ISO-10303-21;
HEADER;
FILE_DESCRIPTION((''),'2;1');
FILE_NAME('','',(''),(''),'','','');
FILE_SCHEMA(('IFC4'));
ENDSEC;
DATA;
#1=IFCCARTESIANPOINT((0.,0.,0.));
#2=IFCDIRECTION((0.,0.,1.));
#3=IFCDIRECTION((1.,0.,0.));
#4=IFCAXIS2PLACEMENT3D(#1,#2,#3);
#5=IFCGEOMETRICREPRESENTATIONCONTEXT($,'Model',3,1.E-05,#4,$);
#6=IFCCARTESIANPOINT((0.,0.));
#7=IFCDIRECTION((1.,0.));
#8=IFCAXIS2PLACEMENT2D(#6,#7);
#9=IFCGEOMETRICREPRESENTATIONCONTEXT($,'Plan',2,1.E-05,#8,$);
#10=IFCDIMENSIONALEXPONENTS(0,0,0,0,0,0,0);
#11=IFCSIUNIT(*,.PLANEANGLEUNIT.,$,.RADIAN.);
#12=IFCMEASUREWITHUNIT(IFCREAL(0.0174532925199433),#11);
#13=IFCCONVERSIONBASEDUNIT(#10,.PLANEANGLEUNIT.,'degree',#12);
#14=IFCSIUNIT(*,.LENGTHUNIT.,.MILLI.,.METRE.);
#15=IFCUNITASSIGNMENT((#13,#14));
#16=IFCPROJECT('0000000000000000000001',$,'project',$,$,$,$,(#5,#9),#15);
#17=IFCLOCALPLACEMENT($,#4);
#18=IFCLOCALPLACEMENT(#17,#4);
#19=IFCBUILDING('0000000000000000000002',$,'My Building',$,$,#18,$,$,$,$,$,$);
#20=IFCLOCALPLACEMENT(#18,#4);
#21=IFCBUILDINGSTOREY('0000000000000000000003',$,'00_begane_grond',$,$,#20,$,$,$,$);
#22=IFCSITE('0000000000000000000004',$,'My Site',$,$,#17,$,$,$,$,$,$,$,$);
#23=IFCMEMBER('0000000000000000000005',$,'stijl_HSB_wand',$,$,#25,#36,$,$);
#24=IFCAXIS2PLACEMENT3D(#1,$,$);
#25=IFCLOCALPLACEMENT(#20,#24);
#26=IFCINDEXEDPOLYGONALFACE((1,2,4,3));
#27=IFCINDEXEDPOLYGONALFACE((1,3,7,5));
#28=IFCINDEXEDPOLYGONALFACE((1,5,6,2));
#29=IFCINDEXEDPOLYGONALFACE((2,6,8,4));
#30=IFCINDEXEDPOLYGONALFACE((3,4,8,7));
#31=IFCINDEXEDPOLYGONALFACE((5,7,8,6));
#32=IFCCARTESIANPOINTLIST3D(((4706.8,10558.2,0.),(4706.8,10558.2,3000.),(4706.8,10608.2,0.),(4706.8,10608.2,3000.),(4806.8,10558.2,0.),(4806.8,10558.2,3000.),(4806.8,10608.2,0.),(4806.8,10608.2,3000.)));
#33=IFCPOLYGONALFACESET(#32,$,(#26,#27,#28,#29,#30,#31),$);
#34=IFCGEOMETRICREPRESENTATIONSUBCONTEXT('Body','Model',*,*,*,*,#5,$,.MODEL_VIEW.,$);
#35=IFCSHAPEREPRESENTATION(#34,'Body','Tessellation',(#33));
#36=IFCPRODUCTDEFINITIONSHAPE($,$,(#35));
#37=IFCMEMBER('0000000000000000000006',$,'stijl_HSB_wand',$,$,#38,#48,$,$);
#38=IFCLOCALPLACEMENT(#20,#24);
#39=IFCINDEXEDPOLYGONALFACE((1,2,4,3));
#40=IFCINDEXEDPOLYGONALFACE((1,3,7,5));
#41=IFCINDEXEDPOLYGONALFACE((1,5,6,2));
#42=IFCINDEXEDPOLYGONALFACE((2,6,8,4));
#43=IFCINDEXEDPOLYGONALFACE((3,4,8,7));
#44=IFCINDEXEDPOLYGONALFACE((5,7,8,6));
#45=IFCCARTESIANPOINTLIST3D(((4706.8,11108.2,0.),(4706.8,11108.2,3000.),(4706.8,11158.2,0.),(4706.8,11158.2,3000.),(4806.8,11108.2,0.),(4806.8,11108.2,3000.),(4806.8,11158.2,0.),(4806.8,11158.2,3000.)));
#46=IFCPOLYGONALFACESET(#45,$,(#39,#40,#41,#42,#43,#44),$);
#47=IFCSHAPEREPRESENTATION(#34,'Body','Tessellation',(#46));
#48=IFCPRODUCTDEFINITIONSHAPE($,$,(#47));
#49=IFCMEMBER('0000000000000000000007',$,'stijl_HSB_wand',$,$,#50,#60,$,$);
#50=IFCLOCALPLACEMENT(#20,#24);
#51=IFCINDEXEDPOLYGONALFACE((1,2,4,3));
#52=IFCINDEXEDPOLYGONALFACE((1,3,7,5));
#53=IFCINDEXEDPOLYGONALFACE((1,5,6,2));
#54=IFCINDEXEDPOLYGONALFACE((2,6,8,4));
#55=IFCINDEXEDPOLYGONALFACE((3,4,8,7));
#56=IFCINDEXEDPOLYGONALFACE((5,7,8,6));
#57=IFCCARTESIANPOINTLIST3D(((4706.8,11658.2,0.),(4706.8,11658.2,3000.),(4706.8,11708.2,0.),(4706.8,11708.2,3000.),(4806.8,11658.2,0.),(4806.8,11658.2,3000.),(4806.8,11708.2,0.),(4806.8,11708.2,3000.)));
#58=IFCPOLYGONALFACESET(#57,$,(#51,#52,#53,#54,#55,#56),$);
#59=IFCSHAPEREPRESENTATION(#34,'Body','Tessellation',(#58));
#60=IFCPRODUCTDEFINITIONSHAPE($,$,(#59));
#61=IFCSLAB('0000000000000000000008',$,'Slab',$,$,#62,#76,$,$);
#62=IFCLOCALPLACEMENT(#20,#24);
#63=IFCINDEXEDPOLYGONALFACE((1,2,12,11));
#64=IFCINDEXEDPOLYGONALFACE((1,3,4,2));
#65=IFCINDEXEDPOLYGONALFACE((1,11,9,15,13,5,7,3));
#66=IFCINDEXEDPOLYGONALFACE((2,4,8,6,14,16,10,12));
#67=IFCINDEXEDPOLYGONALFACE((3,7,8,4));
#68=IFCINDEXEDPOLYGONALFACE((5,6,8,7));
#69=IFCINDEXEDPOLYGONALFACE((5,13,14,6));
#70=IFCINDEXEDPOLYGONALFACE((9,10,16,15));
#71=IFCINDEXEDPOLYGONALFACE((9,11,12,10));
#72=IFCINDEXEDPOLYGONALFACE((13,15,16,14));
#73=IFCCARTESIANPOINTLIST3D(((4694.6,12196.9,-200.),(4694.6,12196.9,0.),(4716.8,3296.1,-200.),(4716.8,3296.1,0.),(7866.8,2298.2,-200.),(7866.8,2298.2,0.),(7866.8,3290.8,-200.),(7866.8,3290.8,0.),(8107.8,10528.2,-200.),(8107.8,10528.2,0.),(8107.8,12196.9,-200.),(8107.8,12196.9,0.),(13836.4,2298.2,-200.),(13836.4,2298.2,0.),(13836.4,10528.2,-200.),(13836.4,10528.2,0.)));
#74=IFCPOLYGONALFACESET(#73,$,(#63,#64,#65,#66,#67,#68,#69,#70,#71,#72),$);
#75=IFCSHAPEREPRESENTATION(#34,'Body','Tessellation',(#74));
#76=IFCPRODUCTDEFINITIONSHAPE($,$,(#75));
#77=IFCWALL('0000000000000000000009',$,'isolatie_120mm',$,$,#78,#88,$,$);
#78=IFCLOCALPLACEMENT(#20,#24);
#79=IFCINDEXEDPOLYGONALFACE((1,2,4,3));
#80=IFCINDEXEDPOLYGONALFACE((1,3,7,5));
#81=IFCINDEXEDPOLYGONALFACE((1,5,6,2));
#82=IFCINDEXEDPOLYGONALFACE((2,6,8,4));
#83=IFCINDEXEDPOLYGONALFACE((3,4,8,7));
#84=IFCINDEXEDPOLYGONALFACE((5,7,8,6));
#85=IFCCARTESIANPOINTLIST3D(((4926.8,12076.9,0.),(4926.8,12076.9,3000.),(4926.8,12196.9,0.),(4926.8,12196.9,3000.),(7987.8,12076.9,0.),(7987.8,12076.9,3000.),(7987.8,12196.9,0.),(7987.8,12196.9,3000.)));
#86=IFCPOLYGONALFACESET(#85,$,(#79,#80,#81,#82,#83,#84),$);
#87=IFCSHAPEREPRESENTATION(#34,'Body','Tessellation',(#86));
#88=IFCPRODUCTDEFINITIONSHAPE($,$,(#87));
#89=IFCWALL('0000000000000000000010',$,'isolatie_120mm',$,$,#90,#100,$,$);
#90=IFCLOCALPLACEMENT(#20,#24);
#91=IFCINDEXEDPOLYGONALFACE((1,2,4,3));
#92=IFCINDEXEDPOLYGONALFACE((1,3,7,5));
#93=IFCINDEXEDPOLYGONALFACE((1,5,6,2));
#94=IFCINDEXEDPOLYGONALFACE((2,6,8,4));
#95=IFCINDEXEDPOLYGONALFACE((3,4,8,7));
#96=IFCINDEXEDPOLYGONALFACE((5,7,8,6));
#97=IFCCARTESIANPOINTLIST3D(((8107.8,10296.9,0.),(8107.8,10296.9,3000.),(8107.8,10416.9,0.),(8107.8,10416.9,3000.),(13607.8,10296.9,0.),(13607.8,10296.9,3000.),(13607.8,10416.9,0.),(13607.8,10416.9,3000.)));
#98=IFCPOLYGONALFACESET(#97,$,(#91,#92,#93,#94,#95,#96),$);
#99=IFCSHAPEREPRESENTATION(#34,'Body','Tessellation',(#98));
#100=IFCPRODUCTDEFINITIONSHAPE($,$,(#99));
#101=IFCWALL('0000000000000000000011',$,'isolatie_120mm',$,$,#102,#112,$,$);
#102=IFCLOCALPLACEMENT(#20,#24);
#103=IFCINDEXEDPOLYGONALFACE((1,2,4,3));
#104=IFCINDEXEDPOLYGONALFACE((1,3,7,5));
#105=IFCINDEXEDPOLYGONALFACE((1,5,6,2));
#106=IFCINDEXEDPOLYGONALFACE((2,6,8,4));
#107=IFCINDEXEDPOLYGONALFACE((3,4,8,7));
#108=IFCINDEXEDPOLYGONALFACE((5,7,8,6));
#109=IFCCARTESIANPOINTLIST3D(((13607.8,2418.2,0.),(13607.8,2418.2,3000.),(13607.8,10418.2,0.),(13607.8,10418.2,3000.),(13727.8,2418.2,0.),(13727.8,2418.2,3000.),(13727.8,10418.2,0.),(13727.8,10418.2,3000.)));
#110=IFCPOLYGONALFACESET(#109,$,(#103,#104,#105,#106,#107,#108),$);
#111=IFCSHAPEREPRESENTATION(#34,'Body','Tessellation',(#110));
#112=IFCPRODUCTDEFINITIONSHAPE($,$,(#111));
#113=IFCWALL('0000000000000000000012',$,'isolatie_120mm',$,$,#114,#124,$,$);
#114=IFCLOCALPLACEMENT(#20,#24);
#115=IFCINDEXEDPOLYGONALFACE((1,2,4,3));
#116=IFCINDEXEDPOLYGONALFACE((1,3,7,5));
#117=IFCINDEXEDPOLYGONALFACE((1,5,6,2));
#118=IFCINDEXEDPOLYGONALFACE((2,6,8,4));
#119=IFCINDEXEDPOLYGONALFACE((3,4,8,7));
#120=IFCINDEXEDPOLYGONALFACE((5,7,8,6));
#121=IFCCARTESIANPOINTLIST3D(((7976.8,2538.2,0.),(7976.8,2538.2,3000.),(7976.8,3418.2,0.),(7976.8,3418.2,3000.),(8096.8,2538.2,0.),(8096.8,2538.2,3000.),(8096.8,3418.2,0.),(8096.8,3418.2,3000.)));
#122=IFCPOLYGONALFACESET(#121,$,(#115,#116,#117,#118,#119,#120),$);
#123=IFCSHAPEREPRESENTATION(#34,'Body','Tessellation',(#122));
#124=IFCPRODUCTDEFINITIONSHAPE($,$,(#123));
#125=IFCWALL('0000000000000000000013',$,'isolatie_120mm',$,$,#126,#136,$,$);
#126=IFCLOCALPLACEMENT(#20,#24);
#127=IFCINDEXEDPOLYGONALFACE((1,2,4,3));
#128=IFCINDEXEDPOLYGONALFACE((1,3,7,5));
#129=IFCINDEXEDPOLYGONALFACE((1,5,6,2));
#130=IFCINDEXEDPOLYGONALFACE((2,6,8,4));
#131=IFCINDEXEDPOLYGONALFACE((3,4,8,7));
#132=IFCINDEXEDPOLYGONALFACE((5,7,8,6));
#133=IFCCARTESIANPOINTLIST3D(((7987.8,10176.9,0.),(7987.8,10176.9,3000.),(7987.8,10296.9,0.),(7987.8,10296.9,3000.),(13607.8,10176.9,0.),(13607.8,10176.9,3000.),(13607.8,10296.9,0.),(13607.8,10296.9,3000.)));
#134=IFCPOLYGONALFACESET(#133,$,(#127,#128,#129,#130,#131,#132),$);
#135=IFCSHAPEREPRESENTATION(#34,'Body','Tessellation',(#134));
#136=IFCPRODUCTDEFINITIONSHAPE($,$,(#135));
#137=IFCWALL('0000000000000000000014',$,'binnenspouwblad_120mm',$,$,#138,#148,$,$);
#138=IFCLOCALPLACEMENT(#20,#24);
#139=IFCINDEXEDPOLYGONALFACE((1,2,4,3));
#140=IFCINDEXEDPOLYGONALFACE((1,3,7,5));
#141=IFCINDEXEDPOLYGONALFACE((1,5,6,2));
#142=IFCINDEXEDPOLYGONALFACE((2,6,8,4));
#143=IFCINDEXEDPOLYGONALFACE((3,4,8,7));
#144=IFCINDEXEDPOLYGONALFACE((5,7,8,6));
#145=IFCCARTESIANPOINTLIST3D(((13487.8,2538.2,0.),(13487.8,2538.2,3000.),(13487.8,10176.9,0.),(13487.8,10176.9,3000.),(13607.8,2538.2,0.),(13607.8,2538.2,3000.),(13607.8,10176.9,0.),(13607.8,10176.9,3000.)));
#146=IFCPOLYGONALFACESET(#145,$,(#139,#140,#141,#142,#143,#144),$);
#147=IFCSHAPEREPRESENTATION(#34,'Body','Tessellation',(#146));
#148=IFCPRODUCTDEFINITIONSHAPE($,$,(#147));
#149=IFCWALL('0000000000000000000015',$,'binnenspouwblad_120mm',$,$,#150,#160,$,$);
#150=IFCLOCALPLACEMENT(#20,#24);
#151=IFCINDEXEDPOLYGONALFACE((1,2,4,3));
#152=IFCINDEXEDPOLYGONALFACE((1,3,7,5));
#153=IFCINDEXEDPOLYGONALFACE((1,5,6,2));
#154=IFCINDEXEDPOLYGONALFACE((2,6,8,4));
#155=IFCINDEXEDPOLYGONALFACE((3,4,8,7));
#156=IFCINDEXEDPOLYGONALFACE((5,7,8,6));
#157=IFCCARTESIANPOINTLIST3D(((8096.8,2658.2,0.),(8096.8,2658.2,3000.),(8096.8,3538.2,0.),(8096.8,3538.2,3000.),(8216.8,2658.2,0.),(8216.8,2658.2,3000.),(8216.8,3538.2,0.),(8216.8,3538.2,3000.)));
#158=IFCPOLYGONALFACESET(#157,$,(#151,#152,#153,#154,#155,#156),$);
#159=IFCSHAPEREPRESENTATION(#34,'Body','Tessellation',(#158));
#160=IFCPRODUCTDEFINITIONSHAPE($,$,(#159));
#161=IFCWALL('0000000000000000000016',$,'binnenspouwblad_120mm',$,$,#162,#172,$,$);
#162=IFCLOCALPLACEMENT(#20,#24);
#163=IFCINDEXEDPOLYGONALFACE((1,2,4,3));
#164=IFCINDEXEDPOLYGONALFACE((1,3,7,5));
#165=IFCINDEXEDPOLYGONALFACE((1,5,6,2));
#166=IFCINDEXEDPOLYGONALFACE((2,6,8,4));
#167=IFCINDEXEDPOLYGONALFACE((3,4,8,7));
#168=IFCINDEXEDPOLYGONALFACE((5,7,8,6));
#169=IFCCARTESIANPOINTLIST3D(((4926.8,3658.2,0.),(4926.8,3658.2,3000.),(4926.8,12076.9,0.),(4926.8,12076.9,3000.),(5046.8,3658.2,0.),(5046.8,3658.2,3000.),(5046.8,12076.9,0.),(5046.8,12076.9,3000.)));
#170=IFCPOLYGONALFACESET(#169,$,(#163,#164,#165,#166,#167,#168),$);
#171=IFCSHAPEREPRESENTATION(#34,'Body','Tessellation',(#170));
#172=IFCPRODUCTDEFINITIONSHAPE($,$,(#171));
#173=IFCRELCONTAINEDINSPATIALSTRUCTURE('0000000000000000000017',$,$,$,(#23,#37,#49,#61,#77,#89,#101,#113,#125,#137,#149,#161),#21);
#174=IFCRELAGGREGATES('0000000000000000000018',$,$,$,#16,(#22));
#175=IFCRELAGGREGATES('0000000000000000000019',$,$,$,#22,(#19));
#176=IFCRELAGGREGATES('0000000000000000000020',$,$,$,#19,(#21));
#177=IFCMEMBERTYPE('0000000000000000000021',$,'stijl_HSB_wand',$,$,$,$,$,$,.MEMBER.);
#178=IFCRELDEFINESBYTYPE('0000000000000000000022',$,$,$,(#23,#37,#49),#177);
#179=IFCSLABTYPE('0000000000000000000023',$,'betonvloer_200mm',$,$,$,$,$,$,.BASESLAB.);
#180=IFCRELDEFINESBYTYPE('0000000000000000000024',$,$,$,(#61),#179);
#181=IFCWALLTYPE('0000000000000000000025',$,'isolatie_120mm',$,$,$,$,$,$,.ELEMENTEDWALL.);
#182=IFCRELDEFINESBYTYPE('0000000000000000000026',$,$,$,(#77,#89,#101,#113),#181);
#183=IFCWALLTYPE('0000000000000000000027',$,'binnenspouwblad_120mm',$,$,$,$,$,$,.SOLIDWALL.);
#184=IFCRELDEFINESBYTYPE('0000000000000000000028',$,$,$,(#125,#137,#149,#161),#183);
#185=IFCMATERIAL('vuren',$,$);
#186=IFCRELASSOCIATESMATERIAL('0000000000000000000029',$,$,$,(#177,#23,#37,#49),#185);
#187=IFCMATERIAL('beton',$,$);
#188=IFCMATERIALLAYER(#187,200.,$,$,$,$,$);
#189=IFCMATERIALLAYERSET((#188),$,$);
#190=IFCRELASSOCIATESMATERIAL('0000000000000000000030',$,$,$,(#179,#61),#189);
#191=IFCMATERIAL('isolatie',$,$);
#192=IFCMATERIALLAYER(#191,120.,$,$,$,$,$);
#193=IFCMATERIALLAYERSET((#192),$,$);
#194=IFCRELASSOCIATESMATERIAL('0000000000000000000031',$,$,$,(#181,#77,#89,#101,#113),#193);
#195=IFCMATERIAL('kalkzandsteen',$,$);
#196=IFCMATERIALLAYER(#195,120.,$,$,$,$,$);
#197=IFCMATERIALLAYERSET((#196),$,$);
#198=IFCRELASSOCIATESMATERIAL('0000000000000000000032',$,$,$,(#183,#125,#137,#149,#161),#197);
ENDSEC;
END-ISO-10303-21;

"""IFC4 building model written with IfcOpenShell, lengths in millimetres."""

from ifc_helpers import new_model, entity, si_unit, converted_unit, frame, origin_with_axes, origin_2d_with_axis, place, context, subcontext, project, spatial, line, indexed_curve, rectangle, outline, extrude, material, layer, layer_set, layer_usage, material_profile, profile_set, profile_usage, type_object, element, save


model = new_model("IFC4")

# Units and contexts
model_context = context("Model", 3, precision=1e-05, world=origin_with_axes())
plan_context = context("Plan", 2, precision=1e-05, world=origin_2d_with_axis())
body_context = subcontext(model_context, "Body", "Model", "MODEL_VIEW")
ifc_project = project(units=[converted_unit("PLANEANGLEUNIT", "degree", entity("IfcReal", 0.0174532925199433), si_unit("PLANEANGLEUNIT", "RADIAN"), dimensions=[0, 0, 0, 0, 0, 0, 0]), si_unit("LENGTHUNIT", "METRE", prefix="MILLI")], contexts=[model_context, plan_context])

# Site, building, storey
site_placement = place(None, origin_with_axes())
site = spatial("IfcSite", under=ifc_project, at=site_placement, Name="My Site")
building_placement = place(site_placement, origin_with_axes())
building = spatial("IfcBuilding", under=site, at=building_placement, Name="My Building")
storey_placement = place(building_placement, origin_with_axes())
storey = spatial("IfcBuildingStorey", under=building, at=storey_placement, Name="00_begane_grond")

# Members
ifc_material_1 = material(Name="vuren")
ifc_material_profile_1 = material_profile(ifc_material_1, rectangle(XDim=100.0, YDim=50.0))
ifc_material_profile_2 = material_profile(ifc_material_1, rectangle(XDim=100.0, YDim=50.0))
ifc_profile_set = profile_set([ifc_material_profile_1, ifc_material_profile_2])
member_type = type_object("IfcMemberType", Name="stijl_HSB_wand", PredefinedType="MEMBER", material=ifc_profile_set)
ifc_profile_usage_1 = profile_usage(ifc_profile_set, cardinal=1)
member_1_placement = place(storey_placement, frame((4806.8, 10558.2, 0.0), z_axis=(0.0, 0.0, 1.0), x_axis=(1.0, 0.0, 0.0)))
element("IfcMember", 1, at=member_1_placement, inside=storey, type_object=member_type, material=ifc_profile_usage_1, Name="stijl_HSB_wand", context=body_context, shape_type="SweptSolid", body=[
    extrude(rectangle(XDim=100.0, YDim=50.0), frame((-50.0, 25.0, 0.0), z_axis=(0.0, 0.0, 1.0), x_axis=(1.0, 0.0, 0.0)), (0.0, 0.0, 1.0), 3000.0),
])
ifc_profile_usage_2 = profile_usage(ifc_profile_set, cardinal=1)
member_2_placement = place(storey_placement, frame((4806.8, 11108.2, 0.0), z_axis=(0.0, 0.0, 1.0), x_axis=(1.0, 0.0, 0.0)))
element("IfcMember", 2, at=member_2_placement, inside=storey, type_object=member_type, material=ifc_profile_usage_2, Name="stijl_HSB_wand", context=body_context, shape_type="SweptSolid", body=[
    extrude(rectangle(XDim=100.0, YDim=50.0), frame((-50.0, 25.0, 0.0), z_axis=(0.0, 0.0, 1.0), x_axis=(1.0, 0.0, 0.0)), (0.0, 0.0, 1.0), 3000.0),
])
ifc_profile_usage_3 = profile_usage(ifc_profile_set, cardinal=1)
member_3_placement = place(storey_placement, frame((4806.8, 11658.2, 0.0), z_axis=(0.0, 0.0, 1.0), x_axis=(1.0, 0.0, 0.0)))
element("IfcMember", 3, at=member_3_placement, inside=storey, type_object=member_type, material=ifc_profile_usage_3, Name="stijl_HSB_wand", context=body_context, shape_type="SweptSolid", body=[
    extrude(rectangle(XDim=100.0, YDim=50.0), frame((-50.0, 25.0, 0.0), z_axis=(0.0, 0.0, 1.0), x_axis=(1.0, 0.0, 0.0)), (0.0, 0.0, 1.0), 3000.0),
])

# Slab
ifc_material_2 = material(Name="beton")
ifc_layer_1 = layer(ifc_material_2, 200.0)
ifc_layer_set_1 = layer_set([ifc_layer_1])
ifc_layer_usage_1 = layer_usage(ifc_layer_set_1, "AXIS3", "POSITIVE", 0.0)
slab_type = type_object("IfcSlabType", Name="betonvloer_200mm", PredefinedType="BASESLAB", material=ifc_layer_set_1)
slab_placement = place(storey_placement, frame((7866.8, 2298.2, -200.0), z_axis=(0.0, 0.0, 1.0), x_axis=(1.0, 0.0, 0.0)))
element("IfcSlab", 4, at=slab_placement, inside=storey, type_object=slab_type, material=ifc_layer_usage_1, Name="Slab", context=body_context, shape_type="SweptSolid", body=[
    extrude(outline(indexed_curve([(241.0, 9898.8), (0.0, 0.0), (5969.7, 0.0), (241.0, 8230.0), (0.0, 992.6), (-3150.0, 997.9), (-3172.1, 9898.8), (5969.7, 8230.0)], segments=[line(5, 2), line(2, 3), line(3, 8), line(8, 4), line(4, 1), line(1, 7), line(7, 6), line(6, 5)], self_intersect=False)), None, (0.0, 0.0, 1.0), 200.0),
])

# Walls
ifc_material_3 = material(Name="isolatie")
ifc_layer_2 = layer(ifc_material_3, 120.0)
ifc_layer_set_2 = layer_set([ifc_layer_2])
ifc_layer_usage_2 = layer_usage(ifc_layer_set_2, "AXIS2", "POSITIVE", 0.0)
wall_type_1 = type_object("IfcWallType", Name="isolatie_120mm", PredefinedType="ELEMENTEDWALL", material=ifc_layer_set_2)
wall_1_placement = place(storey_placement, frame((4926.8, 12076.9, 0.0), z_axis=(0.0, 0.0, 1.0), x_axis=(1.0, 0.0, 0.0)))
element("IfcWall", 5, at=wall_1_placement, inside=storey, type_object=wall_type_1, material=ifc_layer_usage_2, Name="isolatie_120mm", context=body_context, shape_type="SweptSolid", body=[
    extrude(outline(indexed_curve([(0.0, 0.0), (0.0, 120.0), (3061.0, 120.0), (3061.0, 0.0), (0.0, 0.0)], self_intersect=False)), origin_with_axes(), (0.0, 0.0, 1.0), 3000.0),
])
ifc_layer_usage_3 = layer_usage(ifc_layer_set_2, "AXIS2", "POSITIVE", 0.0)
wall_2_placement = place(storey_placement, frame((8107.8, 10296.9, 0.0), z_axis=(0.0, 0.0, 1.0), x_axis=(1.0, -0.000001, 0.0)))
element("IfcWall", 6, at=wall_2_placement, inside=storey, type_object=wall_type_1, material=ifc_layer_usage_3, Name="isolatie_120mm", context=body_context, shape_type="SweptSolid", body=[
    extrude(outline(indexed_curve([(0.0, 0.0), (0.0, 120.0), (5500.0, 120.0), (5500.0, 0.0), (0.0, 0.0)], self_intersect=False)), origin_with_axes(), (0.0, 0.0, 1.0), 3000.0),
])
ifc_layer_usage_4 = layer_usage(ifc_layer_set_2, "AXIS2", "POSITIVE", 0.0)
wall_3_placement = place(storey_placement, frame((13607.8, 10418.2, 0.0), z_axis=(0.0, 0.0, 1.0), x_axis=(-0.000001, -1.0, 0.0)))
element("IfcWall", 7, at=wall_3_placement, inside=storey, type_object=wall_type_1, material=ifc_layer_usage_4, Name="isolatie_120mm", context=body_context, shape_type="SweptSolid", body=[
    extrude(outline(indexed_curve([(0.0, 0.0), (0.0, 120.0), (8000.0, 120.0), (8000.0, 0.0), (0.0, 0.0)], self_intersect=False)), origin_with_axes(), (0.0, 0.0, 1.0), 3000.0),
])
ifc_layer_usage_5 = layer_usage(ifc_layer_set_2, "AXIS2", "POSITIVE", 0.0)
wall_4_placement = place(storey_placement, frame((7976.8, 3418.2, 0.0), z_axis=(0.0, 0.0, 1.0), x_axis=(0.0, -1.0, 0.0)))
element("IfcWall", 8, at=wall_4_placement, inside=storey, type_object=wall_type_1, material=ifc_layer_usage_5, Name="isolatie_120mm", context=body_context, shape_type="SweptSolid", body=[
    extrude(outline(indexed_curve([(0.0, 0.0), (0.0, 120.0), (880.0, 120.0), (880.0, 0.0), (0.0, 0.0)], self_intersect=False)), origin_with_axes(), (0.0, 0.0, 1.0), 3000.0),
])
ifc_material_4 = material(Name="kalkzandsteen")
ifc_layer_3 = layer(ifc_material_4, 120.0)
ifc_layer_set_3 = layer_set([ifc_layer_3])
ifc_layer_usage_6 = layer_usage(ifc_layer_set_3, "AXIS2", "POSITIVE", 0.0)
wall_type_2 = type_object("IfcWallType", Name="binnenspouwblad_120mm", PredefinedType="SOLIDWALL", material=ifc_layer_set_3)
wall_5_placement = place(storey_placement, frame((13607.8, 10296.9, 0.0), z_axis=(0.0, 0.0, 1.0), x_axis=(-1.0, 0.000001, 0.0)))
element("IfcWall", 9, at=wall_5_placement, inside=storey, type_object=wall_type_2, material=ifc_layer_usage_6, Name="isolatie_120mm", context=body_context, shape_type="SweptSolid", body=[
    extrude(outline(indexed_curve([(0.0, 0.0), (0.0, 120.0), (5620.0, 120.0), (5620.0, 0.0), (0.0, 0.0)], self_intersect=False)), origin_with_axes(), (0.0, 0.0, 1.0), 3000.0),
])
ifc_layer_usage_7 = layer_usage(ifc_layer_set_3, "AXIS2", "POSITIVE", 0.0)
wall_6_placement = place(storey_placement, frame((13607.8, 2538.2, 0.0), z_axis=(0.0, 0.0, 1.0), x_axis=(0.000001, 1.0, 0.0)))
element("IfcWall", 10, at=wall_6_placement, inside=storey, type_object=wall_type_2, material=ifc_layer_usage_7, Name="binnenspouwblad_120mm", context=body_context, shape_type="SweptSolid", body=[
    extrude(outline(indexed_curve([(0.0, 0.0), (0.0, 120.0), (7638.7, 120.0), (7638.7, 0.0), (0.0, 0.0)], self_intersect=False)), origin_with_axes(), (0.0, 0.0, 1.0), 3000.0),
])
ifc_layer_usage_8 = layer_usage(ifc_layer_set_3, "AXIS2", "POSITIVE", 0.0)
wall_7_placement = place(storey_placement, frame((8096.8, 3538.2, 0.0), z_axis=(0.0, 0.0, 1.0), x_axis=(-0.000001, -1.0, 0.0)))
element("IfcWall", 11, at=wall_7_placement, inside=storey, type_object=wall_type_2, material=ifc_layer_usage_8, Name="binnenspouwblad_120mm", context=body_context, shape_type="SweptSolid", body=[
    extrude(outline(indexed_curve([(0.0, 0.0), (0.0, 120.0), (880.0, 120.0), (880.0, 0.0), (0.0, 0.0)], self_intersect=False)), origin_with_axes(), (0.0, 0.0, 1.0), 3000.0),
])
ifc_layer_usage_9 = layer_usage(ifc_layer_set_3, "AXIS2", "POSITIVE", 0.0)
wall_8_placement = place(storey_placement, frame((4926.8, 12076.9, 0.0), z_axis=(0.0, 0.0, 1.0), x_axis=(-0.000001, -1.0, 0.0)))
element("IfcWall", 12, at=wall_8_placement, inside=storey, type_object=wall_type_2, material=ifc_layer_usage_9, Name="binnenspouwblad_120mm", context=body_context, shape_type="SweptSolid", body=[
    extrude(outline(indexed_curve([(0.0, 0.0), (0.0, 120.0), (8418.7, 120.0), (8418.7, 0.0), (0.0, 0.0)], self_intersect=False)), origin_with_axes(), (0.0, 0.0, 1.0), 3000.0),
])

save(model, "model.ifc")
